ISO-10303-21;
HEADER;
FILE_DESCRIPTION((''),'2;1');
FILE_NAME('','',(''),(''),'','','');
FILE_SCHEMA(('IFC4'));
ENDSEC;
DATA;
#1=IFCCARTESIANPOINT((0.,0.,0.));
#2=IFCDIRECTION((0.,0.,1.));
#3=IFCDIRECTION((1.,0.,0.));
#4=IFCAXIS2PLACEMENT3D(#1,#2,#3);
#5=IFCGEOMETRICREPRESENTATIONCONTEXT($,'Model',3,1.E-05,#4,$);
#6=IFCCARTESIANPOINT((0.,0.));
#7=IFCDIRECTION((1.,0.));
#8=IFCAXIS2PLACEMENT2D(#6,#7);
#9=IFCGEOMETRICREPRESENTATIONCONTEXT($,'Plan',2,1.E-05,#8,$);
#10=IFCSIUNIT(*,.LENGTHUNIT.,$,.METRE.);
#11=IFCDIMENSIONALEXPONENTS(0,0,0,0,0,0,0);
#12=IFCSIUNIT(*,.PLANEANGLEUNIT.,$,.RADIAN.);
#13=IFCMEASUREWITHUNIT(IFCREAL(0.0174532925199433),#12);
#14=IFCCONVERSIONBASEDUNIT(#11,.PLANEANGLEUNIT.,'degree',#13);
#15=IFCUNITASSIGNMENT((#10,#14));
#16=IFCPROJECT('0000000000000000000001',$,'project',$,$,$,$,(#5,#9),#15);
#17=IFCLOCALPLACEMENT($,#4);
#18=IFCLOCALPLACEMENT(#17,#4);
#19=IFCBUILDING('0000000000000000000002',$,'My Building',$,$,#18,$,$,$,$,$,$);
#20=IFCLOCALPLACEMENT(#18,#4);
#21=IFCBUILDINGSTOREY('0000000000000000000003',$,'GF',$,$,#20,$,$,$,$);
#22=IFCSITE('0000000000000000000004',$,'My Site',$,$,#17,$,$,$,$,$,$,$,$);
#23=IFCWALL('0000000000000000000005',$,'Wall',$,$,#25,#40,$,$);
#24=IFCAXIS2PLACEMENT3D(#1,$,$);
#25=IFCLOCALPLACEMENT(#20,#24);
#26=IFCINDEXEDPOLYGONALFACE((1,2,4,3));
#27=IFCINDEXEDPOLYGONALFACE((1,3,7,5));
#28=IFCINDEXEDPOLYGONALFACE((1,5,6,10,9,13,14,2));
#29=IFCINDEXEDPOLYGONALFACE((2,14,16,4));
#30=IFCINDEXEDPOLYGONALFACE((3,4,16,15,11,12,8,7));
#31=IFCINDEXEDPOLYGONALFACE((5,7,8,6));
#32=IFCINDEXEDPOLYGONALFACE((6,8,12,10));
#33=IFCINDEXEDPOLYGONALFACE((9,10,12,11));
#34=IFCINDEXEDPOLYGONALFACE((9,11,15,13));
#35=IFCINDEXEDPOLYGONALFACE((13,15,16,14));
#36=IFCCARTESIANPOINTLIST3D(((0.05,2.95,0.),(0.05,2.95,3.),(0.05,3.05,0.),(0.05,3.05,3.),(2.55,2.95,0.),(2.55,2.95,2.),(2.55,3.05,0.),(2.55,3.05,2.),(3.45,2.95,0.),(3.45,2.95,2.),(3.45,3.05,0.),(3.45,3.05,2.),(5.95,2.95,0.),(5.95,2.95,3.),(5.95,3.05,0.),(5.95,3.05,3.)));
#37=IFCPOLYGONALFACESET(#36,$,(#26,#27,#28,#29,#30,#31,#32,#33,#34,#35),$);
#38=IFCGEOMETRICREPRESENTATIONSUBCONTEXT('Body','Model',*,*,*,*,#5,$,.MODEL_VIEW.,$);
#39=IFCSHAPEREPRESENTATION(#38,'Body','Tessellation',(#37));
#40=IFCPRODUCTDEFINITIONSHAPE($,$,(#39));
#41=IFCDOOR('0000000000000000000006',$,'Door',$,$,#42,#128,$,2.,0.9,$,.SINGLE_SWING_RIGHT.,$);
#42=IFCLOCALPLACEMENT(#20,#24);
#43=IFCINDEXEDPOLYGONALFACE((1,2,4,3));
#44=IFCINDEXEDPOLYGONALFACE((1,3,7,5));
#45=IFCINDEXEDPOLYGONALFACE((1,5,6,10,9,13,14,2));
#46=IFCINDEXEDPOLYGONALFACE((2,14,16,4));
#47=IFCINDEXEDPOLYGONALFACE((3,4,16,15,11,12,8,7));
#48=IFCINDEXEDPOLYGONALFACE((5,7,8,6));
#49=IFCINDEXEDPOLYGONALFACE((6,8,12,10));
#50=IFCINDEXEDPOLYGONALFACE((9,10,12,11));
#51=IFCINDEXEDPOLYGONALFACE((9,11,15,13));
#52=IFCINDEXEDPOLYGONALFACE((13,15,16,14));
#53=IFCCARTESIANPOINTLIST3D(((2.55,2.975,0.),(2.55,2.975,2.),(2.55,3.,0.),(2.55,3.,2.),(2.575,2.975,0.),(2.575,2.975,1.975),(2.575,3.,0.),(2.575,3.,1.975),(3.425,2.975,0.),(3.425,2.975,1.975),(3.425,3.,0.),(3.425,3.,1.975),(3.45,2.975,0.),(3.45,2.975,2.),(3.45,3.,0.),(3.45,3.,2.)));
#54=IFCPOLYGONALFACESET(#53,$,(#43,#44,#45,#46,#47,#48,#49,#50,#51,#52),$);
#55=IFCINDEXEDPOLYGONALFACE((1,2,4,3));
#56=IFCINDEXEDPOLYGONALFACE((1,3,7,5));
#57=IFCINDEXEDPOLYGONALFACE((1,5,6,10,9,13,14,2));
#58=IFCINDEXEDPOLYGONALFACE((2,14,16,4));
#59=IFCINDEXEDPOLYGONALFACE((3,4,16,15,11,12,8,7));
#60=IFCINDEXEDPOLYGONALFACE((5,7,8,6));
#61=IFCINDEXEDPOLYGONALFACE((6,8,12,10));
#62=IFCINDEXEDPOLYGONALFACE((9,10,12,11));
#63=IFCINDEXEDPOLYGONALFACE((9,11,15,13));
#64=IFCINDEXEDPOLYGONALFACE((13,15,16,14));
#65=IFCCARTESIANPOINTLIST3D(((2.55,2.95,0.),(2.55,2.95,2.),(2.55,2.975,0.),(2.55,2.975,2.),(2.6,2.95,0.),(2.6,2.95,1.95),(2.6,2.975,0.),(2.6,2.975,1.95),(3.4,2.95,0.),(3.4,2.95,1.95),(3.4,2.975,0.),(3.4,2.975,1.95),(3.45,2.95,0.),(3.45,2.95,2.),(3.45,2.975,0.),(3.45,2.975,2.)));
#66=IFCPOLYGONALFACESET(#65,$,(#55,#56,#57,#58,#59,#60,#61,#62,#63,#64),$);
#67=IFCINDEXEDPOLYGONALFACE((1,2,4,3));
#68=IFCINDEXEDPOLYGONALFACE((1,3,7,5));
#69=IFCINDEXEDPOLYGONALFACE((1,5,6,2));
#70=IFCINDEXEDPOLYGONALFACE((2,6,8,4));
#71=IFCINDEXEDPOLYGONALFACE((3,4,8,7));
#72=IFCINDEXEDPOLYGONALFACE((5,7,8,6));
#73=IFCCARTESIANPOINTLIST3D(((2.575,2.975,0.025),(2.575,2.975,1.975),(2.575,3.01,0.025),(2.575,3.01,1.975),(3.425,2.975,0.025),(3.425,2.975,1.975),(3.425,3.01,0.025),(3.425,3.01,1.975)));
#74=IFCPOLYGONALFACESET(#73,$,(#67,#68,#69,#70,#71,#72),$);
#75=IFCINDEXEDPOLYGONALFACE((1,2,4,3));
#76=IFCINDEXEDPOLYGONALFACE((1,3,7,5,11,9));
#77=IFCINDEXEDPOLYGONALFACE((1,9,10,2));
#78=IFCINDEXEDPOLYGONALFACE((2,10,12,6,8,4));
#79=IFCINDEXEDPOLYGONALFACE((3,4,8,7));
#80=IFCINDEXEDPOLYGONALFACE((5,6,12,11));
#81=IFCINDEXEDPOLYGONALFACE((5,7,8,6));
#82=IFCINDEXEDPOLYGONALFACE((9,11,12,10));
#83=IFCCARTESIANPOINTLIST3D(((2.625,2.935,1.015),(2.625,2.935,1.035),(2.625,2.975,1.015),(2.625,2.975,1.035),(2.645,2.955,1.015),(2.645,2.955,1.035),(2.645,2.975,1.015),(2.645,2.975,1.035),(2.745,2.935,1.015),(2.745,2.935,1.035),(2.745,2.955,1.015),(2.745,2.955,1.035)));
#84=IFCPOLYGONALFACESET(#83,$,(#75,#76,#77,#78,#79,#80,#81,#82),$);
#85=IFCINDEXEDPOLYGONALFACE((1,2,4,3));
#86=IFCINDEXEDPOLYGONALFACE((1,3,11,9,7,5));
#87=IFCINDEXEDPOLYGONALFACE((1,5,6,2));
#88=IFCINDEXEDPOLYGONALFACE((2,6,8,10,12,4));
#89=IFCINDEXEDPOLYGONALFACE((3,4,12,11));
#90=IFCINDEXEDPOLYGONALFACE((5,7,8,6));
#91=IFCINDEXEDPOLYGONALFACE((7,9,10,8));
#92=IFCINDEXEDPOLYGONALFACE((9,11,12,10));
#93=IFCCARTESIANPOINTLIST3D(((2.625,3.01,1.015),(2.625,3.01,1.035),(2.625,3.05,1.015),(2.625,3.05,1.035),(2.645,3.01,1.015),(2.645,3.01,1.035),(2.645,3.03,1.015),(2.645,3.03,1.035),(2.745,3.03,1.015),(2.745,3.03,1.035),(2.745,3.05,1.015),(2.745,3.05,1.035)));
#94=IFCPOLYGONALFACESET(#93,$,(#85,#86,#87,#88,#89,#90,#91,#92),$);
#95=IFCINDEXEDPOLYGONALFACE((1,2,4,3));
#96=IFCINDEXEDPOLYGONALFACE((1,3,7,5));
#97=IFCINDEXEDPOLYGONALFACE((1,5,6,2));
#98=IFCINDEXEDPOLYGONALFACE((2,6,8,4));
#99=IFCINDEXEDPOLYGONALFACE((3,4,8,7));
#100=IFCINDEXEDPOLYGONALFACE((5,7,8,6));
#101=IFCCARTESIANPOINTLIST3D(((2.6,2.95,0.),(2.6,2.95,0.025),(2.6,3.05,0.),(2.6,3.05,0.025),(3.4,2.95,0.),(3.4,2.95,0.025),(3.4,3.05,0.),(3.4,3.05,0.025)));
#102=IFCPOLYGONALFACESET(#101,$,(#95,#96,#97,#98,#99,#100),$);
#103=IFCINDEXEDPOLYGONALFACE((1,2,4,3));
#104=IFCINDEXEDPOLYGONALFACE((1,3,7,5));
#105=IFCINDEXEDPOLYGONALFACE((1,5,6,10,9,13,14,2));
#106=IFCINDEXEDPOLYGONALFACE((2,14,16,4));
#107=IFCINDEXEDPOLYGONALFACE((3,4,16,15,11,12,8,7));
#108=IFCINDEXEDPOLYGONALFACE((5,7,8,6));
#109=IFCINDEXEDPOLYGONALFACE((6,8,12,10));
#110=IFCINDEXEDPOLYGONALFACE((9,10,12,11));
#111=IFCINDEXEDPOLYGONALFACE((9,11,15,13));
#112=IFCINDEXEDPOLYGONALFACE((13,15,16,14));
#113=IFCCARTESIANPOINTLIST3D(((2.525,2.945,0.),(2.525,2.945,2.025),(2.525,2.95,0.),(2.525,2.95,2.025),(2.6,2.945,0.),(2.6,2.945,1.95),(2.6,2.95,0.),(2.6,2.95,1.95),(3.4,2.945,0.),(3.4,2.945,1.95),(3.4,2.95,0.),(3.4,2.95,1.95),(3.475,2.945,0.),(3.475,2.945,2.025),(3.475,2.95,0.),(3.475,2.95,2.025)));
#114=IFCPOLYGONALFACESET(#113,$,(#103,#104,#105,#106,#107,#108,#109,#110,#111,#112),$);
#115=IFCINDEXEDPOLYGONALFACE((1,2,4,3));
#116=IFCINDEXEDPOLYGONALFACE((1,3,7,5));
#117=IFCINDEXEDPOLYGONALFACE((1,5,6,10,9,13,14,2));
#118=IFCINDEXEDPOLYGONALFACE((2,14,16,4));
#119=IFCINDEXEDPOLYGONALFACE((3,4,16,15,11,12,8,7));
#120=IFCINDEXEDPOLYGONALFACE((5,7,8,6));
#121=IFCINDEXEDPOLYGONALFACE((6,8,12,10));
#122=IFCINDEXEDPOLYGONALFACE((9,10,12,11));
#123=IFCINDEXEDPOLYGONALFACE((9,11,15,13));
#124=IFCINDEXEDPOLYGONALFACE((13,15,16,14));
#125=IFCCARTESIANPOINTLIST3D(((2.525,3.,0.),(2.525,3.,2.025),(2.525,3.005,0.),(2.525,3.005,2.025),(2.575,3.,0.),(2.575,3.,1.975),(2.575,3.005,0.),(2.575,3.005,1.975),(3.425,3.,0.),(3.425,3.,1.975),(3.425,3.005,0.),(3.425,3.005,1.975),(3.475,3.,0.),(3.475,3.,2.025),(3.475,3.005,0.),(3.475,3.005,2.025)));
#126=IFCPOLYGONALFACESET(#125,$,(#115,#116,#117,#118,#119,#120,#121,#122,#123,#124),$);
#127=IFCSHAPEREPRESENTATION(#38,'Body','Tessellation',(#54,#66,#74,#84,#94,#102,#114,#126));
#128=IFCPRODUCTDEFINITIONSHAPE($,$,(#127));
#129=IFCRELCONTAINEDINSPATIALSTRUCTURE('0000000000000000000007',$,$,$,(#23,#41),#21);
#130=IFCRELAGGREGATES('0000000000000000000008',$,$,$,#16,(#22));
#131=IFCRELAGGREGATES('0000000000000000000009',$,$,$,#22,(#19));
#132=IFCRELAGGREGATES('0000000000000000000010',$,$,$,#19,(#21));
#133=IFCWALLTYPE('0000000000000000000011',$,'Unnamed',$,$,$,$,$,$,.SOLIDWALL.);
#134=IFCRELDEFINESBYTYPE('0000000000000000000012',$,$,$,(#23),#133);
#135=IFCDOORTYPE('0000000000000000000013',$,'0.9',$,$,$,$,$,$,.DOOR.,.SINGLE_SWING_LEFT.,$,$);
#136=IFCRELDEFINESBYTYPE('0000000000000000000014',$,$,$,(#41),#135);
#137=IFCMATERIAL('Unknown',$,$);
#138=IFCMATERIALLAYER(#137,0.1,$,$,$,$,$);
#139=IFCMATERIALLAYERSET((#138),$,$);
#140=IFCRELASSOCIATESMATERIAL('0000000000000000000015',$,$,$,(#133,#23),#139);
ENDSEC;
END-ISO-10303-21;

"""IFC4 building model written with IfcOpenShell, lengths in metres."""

from ifc_helpers import new_model, entity, si_unit, converted_unit, frame, origin_with_axes, origin_2d_with_axis, place, context, subcontext, project, spatial, line, indexed_curve, outline, extrude, shape, source, transform, mapped, material, layer, layer_set, layer_usage, type_object, type_shapes, element, fill, save


model = new_model("IFC4")

# Units and contexts
model_context = context("Model", 3, precision=1e-05, world=origin_with_axes())
plan_context = context("Plan", 2, precision=1e-05, world=origin_2d_with_axis())
body_context_1 = subcontext(model_context, "Body", "Model", "MODEL_VIEW")
body_context_2 = subcontext(plan_context, "Body", "Plan", "PLAN_VIEW")
ifc_project = project(units=[si_unit("LENGTHUNIT", "METRE"), converted_unit("PLANEANGLEUNIT", "degree", entity("IfcReal", 0.0174532925199433), si_unit("PLANEANGLEUNIT", "RADIAN"), dimensions=[0, 0, 0, 0, 0, 0, 0])], contexts=[model_context, plan_context])

# Site, building, storey
site_placement = place(None, origin_with_axes())
site = spatial("IfcSite", under=ifc_project, at=site_placement, Name="My Site")
building_placement = place(site_placement, origin_with_axes())
building = spatial("IfcBuilding", under=site, at=building_placement, Name="My Building")
storey_placement = place(building_placement, origin_with_axes())
storey = spatial("IfcBuildingStorey", under=building, at=storey_placement, Name="GF")

# Shared definitions
ifc_material = material(Name="Unknown")

# Shared definitions
ifc_layer_1 = layer(ifc_material, 0.1)
ifc_layer_set_1 = layer_set([ifc_layer_1])
wall_type = type_object("IfcWallType", Name="Unnamed", PredefinedType="SOLIDWALL", material=ifc_layer_set_1)
shared_shape_1 = source(origin_with_axes(), body_context_1, "Body", "SweptSolid", [
    extrude(outline(indexed_curve([(0.0, 0.0), (0.9, 0.0), (0.9, 2.0), (0.0, 2.0)], segments=[line(1, 2, 3, 4, 1)])), frame((0.0, -0.6, 0.0), z_axis=(0.0, -1.0, 0.0), x_axis=(1.0, 0.0, 0.0)), (0.0, 0.0, -1.0), 1.2),
])
door_type_1 = type_object("IfcDoorType", Name="0.9", OperationType="SINGLE_SWING_LEFT", PredefinedType="DOOR")
shared_shape_2 = source(origin_with_axes(), body_context_1, "Body", "SweptSolid", [
    extrude(outline(indexed_curve([(0.0, 0.0), (0.0, 2.0), (0.9, 2.0), (0.9, 0.0), (0.875, 0.0), (0.875, 1.975), (0.025, 1.975), (0.025, 0.0)], segments=[line(1, 2, 3, 4, 5, 6, 7, 8, 1)])), frame((0.0, 0.025, 0.0), z_axis=(0.0, -1.0, 0.0), x_axis=(1.0, 0.0, 0.0)), (0.0, 0.0, -1.0), 0.025),
    extrude(outline(indexed_curve([(0.0, 0.0), (0.0, 2.0), (0.9, 2.0), (0.9, 0.0), (0.85, 0.0), (0.85, 1.95), (0.05, 1.95), (0.05, 0.0)], segments=[line(1, 2, 3, 4, 5, 6, 7, 8, 1)])), frame((0.0, 0.0, 0.0), z_axis=(0.0, -1.0, 0.0), x_axis=(1.0, 0.0, 0.0)), (0.0, 0.0, -1.0), 0.025),
    extrude(outline(indexed_curve([(0.0, 0.0), (0.85, 0.0), (0.85, 0.035), (0.0, 0.035)], segments=[line(1, 2, 3, 4, 1)])), frame((0.025, 0.025, 0.025), z_axis=(0.0, 0.0, 1.0), x_axis=(1.0, 0.0, 0.0)), (0.0, 0.0, 1.0), 1.95),
    extrude(outline(indexed_curve([(0.0, 0.0), (0.0, -0.04), (0.12, -0.04), (0.12, -0.02), (0.02, -0.02), (0.02, 0.0)], segments=[line(1, 2, 3, 4, 5, 6, 1)])), frame((0.075, 0.025, 1.015), z_axis=(0.0, 0.0, 1.0), x_axis=(1.0, 0.0, 0.0)), (0.0, 0.0, 1.0), 0.02),
    extrude(outline(indexed_curve([(0.0, 0.0), (0.0, 0.04), (0.12, 0.04), (0.12, 0.02), (0.02, 0.02), (0.02, 0.0)], segments=[line(1, 2, 3, 4, 5, 6, 1)])), frame((0.075, 0.06, 1.015), z_axis=(0.0, 0.0, 1.0), x_axis=(1.0, 0.0, 0.0)), (0.0, 0.0, 1.0), 0.02),
    extrude(outline(indexed_curve([(0.0, 0.0), (0.8, 0.0), (0.8, 0.1), (0.0, 0.1)], segments=[line(1, 2, 3, 4, 1)])), frame((0.05, 0.0, 0.0), z_axis=(0.0, 0.0, 1.0), x_axis=(1.0, 0.0, 0.0)), (0.0, 0.0, 1.0), 0.025),
    extrude(outline(indexed_curve([(0.0, 0.0), (0.0, 2.025), (0.95, 2.025), (0.95, 0.0), (0.875, 0.0), (0.875, 1.95), (0.075, 1.95), (0.075, 0.0)], segments=[line(1, 2, 3, 4, 5, 6, 7, 8, 1)])), frame((-0.025, -0.005, 0.0), z_axis=(0.0, -1.0, 0.0), x_axis=(1.0, 0.0, 0.0)), (0.0, 0.0, -1.0), 0.005),
    extrude(outline(indexed_curve([(0.0, 0.0), (0.0, 2.025), (0.95, 2.025), (0.95, 0.0), (0.9, 0.0), (0.9, 1.975), (0.05, 1.975), (0.05, 0.0)], segments=[line(1, 2, 3, 4, 5, 6, 7, 8, 1)])), frame((-0.025, 0.05, 0.0), z_axis=(0.0, -1.0, 0.0), x_axis=(1.0, 0.0, 0.0)), (0.0, 0.0, -1.0), 0.005),
])
shared_shape_3 = source(origin_with_axes(), body_context_2, "Body", "Curve2D", [
    entity("IfcIndexedPolyCurve", entity("IfcCartesianPointList2D", [[0.0, 0.0], [0.0, 0.05], [0.025, 0.05], [0.025, 0.025], [0.05, 0.025], [0.05, 0.0]]), [entity("IfcLineIndex", [1, 2, 3, 4, 5, 6, 1])]),
    entity("IfcIndexedPolyCurve", entity("IfcCartesianPointList2D", [[0.9, 0.0], [0.9, 0.05], [0.875, 0.05], [0.875, 0.025], [0.85, 0.025], [0.85, 0.0]]), [entity("IfcLineIndex", [1, 2, 3, 4, 5, 6, 1])]),
    entity("IfcTrimmedCurve", entity("IfcEllipse", entity("IfcAxis2Placement2D", entity("IfcCartesianPoint", [0.84, 0.05]), entity("IfcDirection", [1.0, 0.0])), 0.815, 0.85), [entity("IfcCartesianPoint", [0.84, 0.9])], [entity("IfcCartesianPoint", [0.025, 0.05])], True, "CARTESIAN"),
    entity("IfcIndexedPolyCurve", entity("IfcCartesianPointList2D", [[0.875, 0.05], [0.84, 0.05], [0.84, 0.9], [0.875, 0.9]]), [entity("IfcLineIndex", [1, 2, 3, 4, 1])]),
])
type_shapes(door_type_1, [shared_shape_2, shared_shape_3])

# Wall, opening, door
ifc_layer_usage_1 = layer_usage(ifc_layer_set_1, "AXIS2", "POSITIVE", 0.0)
wall_1_placement = place(storey_placement, frame((0.05, 2.95, 0.0), z_axis=(0.0, 0.0, 1.0), x_axis=(1.0, 0.0, 0.0)))
wall_1 = element("IfcWall", 1, at=wall_1_placement, inside=storey, type_object=wall_type, material=ifc_layer_usage_1, Name="Wall", context=body_context_1, shape_type="SweptSolid", body=[
    extrude(outline(indexed_curve([(0.0, 0.0), (0.0, 0.1), (5.9, 0.1), (5.9, 0.0)], segments=[line(1, 2, 3, 4, 1)])), origin_with_axes(), (0.0, 0.0, 1.0), 3.0),
])
opening_1_placement = place(wall_1_placement, frame((2.5, 0.0, 0.0), z_axis=(0.0, 0.0, 1.0), x_axis=(1.0, 0.0, 0.0)))
opening_1 = element("IfcOpeningElement", 2, at=opening_1_placement, cuts=wall_1, PredefinedType="OPENING", context=body_context_1, shape_type="MappedRepresentation", body=[
    mapped(shared_shape_1, transform((0.0, 0.0, 0.0), x_axis=(1.0, 0.0, 0.0), y_axis=(0.0, 1.0, 0.0), z_axis=(0.0, 0.0, 1.0), scale=1.0)),
])
door_1_placement = place(opening_1_placement, origin_with_axes())
door_1 = element("IfcDoor", 3, at=door_1_placement, inside=storey, type_object=door_type_1, Name="Door", OperationType="SINGLE_SWING_RIGHT", OverallHeight=2.0, OverallWidth=0.9, shapes=[
    shape(body_context_1, "Body", "MappedRepresentation", [mapped(shared_shape_2, transform((0.0, 0.0, 0.0), x_axis=(1.0, 0.0, 0.0), y_axis=(0.0, 1.0, 0.0), z_axis=(0.0, 0.0, 1.0), scale=1.0))]),
    shape(body_context_2, "Body", "MappedRepresentation", [mapped(shared_shape_3, transform((0.0, 0.0, 0.0), x_axis=(1.0, 0.0, 0.0), y_axis=(0.0, 1.0, 0.0), z_axis=(0.0, 0.0, 1.0), scale=1.0))]),
])
fill(opening_1, door_1)

save(model, "model.ifc")
